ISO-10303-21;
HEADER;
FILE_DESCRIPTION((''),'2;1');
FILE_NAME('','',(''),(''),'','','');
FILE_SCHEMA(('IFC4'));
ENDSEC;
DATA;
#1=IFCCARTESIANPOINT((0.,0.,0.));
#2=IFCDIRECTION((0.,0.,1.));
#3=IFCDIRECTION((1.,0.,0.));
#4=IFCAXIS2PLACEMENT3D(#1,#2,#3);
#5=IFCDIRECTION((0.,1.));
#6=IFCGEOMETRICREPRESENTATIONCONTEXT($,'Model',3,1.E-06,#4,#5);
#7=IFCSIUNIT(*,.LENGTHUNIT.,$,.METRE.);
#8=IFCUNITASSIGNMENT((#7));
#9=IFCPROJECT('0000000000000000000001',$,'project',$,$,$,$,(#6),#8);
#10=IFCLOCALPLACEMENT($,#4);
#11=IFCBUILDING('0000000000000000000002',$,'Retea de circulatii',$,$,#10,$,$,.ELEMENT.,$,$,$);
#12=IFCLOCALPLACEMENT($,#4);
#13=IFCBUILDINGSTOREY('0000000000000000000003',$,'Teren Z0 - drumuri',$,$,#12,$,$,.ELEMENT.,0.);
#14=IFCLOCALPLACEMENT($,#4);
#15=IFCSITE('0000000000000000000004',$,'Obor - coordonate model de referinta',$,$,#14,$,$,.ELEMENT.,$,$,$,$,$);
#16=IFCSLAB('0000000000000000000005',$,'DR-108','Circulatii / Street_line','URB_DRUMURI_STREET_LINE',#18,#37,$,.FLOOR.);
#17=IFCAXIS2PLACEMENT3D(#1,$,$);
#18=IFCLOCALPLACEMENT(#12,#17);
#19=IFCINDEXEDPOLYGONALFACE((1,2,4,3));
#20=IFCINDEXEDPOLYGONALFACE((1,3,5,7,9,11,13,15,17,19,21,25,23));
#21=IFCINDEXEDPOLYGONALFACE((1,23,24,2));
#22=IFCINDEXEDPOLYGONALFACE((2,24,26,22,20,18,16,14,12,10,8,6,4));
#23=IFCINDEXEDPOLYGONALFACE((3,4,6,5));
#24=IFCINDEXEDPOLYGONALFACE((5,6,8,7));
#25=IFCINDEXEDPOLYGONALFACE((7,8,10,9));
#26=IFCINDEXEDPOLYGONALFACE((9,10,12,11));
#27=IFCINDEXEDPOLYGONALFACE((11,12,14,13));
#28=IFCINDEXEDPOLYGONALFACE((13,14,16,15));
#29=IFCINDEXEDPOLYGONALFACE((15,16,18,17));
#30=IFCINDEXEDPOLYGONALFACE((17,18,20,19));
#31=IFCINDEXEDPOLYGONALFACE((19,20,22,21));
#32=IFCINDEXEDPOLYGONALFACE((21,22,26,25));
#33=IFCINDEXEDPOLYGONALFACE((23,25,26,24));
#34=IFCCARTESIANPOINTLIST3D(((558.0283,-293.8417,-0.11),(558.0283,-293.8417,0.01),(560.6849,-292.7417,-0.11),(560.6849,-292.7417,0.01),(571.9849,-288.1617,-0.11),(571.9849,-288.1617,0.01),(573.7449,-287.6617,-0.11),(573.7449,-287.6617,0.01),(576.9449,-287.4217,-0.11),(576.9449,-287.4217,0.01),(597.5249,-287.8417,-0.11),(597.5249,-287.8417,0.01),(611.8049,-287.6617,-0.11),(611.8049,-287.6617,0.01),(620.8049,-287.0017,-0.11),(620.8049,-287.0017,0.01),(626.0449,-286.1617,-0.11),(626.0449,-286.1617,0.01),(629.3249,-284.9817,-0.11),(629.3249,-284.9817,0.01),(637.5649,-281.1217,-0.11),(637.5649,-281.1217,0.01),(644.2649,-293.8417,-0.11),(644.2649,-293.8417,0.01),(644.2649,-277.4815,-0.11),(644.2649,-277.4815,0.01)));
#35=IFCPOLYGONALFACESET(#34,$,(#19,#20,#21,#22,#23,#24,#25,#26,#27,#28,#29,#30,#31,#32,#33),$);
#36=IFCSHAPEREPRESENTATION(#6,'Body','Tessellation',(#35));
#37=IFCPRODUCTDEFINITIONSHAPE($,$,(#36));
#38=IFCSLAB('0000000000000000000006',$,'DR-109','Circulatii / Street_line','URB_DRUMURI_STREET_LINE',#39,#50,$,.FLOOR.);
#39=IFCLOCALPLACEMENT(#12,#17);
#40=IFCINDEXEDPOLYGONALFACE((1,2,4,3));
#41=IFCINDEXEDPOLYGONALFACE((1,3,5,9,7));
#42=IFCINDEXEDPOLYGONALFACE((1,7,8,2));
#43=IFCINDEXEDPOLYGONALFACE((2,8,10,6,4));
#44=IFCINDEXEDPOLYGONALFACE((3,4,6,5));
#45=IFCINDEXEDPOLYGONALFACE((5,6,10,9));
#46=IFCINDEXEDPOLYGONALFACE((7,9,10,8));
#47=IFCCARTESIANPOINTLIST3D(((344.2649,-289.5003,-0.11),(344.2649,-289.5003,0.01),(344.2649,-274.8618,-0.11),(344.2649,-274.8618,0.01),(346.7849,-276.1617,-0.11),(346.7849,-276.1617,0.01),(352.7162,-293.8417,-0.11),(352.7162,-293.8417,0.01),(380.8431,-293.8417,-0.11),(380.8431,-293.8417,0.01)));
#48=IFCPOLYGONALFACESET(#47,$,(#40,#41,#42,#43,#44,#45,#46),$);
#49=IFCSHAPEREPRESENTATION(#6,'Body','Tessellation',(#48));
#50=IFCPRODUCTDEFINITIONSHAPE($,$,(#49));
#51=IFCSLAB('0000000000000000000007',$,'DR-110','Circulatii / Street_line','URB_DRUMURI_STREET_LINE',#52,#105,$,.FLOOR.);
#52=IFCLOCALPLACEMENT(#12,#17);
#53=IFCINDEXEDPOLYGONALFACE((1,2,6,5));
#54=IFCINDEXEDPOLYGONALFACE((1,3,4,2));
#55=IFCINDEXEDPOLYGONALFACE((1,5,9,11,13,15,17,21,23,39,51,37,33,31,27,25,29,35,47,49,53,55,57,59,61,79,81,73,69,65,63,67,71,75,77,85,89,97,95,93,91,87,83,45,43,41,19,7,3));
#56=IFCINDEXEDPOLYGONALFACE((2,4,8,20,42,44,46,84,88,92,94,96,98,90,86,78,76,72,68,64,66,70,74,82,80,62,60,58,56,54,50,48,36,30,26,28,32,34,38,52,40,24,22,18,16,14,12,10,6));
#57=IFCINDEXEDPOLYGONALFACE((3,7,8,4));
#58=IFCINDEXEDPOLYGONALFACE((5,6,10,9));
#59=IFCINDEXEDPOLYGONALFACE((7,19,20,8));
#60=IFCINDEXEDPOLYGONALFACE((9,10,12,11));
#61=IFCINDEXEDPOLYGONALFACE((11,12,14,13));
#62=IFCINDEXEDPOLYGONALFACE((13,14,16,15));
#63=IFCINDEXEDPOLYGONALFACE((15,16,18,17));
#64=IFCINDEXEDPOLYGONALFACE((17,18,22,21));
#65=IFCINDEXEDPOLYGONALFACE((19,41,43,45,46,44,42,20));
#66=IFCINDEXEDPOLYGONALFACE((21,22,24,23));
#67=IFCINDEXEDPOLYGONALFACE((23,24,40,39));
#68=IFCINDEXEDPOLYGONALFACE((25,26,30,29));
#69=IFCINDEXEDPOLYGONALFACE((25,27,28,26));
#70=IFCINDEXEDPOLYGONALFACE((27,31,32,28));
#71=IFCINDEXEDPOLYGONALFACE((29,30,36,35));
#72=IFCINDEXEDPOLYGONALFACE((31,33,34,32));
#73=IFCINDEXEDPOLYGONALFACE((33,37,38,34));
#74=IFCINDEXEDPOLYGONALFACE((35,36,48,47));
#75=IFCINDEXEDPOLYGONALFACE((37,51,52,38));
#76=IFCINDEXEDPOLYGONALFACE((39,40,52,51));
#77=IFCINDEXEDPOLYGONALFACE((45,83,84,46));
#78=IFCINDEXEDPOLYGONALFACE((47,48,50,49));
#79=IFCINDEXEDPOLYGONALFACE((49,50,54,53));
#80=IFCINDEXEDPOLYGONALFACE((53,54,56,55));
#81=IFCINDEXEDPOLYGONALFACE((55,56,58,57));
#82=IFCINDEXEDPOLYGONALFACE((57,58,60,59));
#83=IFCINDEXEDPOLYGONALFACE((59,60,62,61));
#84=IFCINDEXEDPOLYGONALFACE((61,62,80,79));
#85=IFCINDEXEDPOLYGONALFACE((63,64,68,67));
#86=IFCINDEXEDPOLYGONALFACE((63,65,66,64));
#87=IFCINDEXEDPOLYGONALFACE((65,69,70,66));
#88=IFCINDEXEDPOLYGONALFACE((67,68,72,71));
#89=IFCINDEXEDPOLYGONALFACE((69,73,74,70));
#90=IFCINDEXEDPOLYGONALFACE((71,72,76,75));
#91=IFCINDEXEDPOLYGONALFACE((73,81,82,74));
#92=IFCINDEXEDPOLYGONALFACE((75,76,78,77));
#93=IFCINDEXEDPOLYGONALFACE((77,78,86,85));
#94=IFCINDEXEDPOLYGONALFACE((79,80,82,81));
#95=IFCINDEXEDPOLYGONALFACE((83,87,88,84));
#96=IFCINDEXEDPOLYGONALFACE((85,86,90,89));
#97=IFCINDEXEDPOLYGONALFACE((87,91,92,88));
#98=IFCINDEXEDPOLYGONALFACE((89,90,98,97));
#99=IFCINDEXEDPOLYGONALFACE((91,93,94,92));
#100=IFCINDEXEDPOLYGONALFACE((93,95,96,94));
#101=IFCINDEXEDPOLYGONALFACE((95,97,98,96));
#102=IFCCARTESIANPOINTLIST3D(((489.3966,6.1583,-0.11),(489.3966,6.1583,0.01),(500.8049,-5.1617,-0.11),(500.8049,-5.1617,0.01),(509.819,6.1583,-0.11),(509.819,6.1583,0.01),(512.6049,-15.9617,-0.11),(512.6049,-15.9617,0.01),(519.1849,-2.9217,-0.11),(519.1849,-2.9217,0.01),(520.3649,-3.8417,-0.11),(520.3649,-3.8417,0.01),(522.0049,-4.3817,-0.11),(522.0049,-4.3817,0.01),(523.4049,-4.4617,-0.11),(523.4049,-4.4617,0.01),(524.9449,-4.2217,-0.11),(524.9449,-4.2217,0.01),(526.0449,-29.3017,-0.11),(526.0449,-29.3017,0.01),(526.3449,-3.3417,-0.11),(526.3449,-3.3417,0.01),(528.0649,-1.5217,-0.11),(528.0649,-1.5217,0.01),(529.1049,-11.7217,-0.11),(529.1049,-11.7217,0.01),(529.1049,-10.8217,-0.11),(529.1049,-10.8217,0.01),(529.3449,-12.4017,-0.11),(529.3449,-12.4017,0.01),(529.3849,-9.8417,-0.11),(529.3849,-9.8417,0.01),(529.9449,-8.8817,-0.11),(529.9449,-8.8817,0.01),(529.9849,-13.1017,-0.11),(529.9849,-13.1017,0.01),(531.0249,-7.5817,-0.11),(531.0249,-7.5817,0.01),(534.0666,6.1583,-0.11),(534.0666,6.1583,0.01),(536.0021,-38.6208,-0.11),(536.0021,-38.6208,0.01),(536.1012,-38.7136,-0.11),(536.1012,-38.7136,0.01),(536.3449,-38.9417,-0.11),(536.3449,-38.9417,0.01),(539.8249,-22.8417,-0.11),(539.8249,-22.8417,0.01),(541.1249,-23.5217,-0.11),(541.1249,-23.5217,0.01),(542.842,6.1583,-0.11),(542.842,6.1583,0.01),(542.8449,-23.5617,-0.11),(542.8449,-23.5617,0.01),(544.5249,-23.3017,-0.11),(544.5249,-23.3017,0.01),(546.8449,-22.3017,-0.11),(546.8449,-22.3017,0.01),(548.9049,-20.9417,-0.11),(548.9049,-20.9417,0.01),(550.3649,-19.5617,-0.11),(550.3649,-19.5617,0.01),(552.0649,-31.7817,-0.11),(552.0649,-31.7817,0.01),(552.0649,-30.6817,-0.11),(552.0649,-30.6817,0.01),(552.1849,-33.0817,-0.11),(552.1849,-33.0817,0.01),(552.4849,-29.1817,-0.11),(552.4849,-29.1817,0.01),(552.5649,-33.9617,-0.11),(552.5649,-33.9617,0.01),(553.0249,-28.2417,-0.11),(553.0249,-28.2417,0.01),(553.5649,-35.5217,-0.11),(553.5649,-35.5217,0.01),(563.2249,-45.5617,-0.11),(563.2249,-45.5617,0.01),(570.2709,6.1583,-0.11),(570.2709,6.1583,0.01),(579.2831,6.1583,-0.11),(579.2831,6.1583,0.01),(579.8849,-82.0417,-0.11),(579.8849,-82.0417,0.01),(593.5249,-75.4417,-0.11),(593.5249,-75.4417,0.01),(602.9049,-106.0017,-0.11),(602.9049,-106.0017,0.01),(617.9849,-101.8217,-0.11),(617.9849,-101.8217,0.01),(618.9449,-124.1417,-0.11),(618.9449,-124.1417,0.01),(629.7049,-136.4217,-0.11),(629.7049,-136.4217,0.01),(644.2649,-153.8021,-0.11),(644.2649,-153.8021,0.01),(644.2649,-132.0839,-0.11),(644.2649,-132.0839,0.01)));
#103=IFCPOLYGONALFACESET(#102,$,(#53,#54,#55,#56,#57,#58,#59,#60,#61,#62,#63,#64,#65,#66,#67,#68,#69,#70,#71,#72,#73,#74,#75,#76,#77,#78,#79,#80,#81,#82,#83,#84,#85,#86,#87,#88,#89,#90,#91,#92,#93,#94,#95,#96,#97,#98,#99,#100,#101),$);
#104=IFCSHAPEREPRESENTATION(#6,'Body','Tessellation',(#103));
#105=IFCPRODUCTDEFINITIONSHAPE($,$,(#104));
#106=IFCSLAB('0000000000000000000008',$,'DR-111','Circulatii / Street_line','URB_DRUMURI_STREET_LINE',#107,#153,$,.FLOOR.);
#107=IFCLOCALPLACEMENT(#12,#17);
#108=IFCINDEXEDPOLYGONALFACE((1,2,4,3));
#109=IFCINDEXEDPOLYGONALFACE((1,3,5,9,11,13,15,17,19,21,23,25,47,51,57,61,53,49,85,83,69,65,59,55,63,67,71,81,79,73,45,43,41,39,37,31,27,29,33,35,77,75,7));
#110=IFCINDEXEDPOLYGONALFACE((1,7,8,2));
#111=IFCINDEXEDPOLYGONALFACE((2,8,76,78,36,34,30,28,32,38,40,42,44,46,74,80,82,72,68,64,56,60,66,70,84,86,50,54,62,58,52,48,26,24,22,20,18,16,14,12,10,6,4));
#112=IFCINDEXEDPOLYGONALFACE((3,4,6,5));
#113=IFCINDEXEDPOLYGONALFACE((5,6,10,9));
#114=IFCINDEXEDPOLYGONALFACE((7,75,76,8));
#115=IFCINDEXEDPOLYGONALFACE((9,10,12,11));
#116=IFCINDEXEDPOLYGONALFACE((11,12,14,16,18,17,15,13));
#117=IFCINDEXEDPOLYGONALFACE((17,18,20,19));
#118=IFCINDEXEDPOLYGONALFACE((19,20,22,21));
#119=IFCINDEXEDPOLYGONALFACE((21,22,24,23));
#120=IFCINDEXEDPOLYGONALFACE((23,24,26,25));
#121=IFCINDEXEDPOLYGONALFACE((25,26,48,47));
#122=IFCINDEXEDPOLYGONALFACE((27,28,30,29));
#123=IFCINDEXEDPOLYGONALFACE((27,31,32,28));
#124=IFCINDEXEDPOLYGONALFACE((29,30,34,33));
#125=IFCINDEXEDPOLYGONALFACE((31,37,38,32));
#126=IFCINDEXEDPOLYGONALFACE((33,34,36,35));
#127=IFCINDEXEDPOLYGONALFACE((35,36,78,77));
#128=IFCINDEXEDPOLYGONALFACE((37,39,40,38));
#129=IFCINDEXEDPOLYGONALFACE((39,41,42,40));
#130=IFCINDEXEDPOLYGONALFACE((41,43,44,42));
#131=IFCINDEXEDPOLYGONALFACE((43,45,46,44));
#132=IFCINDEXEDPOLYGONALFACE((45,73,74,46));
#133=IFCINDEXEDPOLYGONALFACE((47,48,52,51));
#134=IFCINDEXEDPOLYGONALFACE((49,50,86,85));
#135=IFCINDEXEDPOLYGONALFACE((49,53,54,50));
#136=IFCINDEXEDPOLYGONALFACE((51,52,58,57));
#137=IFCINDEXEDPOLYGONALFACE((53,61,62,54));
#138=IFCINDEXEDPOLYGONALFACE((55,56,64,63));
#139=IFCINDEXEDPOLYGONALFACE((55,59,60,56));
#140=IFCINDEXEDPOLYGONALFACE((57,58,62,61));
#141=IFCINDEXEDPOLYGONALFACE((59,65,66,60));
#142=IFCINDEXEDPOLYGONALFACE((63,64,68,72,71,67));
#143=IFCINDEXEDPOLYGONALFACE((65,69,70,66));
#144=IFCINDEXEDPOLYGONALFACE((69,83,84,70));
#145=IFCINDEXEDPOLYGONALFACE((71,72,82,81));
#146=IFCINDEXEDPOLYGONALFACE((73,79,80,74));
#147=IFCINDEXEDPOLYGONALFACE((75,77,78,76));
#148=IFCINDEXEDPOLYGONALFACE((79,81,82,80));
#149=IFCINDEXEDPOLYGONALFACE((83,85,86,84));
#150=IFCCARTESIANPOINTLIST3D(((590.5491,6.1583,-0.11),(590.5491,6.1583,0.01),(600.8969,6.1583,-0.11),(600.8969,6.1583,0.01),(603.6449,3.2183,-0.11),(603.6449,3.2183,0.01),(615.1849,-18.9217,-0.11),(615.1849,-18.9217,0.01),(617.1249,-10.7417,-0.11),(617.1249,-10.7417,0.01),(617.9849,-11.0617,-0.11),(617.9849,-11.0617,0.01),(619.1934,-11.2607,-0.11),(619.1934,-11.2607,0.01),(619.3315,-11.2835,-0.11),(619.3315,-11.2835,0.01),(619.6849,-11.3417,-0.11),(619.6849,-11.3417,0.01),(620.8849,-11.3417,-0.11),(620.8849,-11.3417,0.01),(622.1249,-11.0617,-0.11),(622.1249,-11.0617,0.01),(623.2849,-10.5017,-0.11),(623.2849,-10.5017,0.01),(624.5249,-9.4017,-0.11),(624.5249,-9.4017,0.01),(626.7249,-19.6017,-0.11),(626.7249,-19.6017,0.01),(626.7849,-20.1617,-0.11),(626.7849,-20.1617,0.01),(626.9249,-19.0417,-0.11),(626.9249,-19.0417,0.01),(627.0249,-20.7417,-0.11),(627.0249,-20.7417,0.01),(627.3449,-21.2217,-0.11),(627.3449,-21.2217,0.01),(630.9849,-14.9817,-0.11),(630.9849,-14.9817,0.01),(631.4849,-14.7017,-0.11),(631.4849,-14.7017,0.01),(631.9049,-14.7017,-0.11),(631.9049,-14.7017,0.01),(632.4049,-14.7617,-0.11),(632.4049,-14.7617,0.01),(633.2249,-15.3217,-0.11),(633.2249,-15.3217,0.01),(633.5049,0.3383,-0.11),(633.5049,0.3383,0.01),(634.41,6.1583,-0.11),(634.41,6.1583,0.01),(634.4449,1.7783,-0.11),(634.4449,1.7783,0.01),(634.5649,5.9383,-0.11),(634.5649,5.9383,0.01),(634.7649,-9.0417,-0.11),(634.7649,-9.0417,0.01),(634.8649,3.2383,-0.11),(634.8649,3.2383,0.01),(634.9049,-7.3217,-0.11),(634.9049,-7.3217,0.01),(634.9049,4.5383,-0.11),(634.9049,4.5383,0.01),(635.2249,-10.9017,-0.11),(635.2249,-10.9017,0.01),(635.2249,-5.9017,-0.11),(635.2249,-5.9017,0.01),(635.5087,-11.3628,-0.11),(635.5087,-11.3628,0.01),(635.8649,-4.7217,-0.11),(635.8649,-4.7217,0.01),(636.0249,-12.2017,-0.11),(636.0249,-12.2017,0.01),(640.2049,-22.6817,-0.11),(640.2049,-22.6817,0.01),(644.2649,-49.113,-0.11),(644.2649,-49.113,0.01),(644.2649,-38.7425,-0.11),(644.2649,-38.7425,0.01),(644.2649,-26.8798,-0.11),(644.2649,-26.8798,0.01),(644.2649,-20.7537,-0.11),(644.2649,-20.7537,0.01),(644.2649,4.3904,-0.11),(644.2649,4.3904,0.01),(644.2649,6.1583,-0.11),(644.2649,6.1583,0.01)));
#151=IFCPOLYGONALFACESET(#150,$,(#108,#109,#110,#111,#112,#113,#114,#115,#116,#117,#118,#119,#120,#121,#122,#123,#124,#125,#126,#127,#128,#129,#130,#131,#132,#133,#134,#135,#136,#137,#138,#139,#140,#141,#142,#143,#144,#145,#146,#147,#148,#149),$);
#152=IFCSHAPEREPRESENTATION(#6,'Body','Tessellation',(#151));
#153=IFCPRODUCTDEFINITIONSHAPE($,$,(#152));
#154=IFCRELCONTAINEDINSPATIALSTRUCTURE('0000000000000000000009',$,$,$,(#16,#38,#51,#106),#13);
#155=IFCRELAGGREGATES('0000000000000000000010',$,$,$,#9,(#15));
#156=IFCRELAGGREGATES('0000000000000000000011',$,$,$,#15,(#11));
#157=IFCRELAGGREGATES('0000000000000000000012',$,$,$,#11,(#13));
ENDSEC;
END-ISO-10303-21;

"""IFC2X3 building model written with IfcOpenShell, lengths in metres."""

from ifc_helpers import new_model, si_unit, direction, frame, origin_with_axes, place, context, project, spatial, polyline, outline, extrude, element, save


model = new_model("IFC2X3")

# Units and contexts
model_context = context("Model", 3, precision=1e-06, world=origin_with_axes(), true_north=direction((0.0, 1.0)))
ifc_project = project(units=[si_unit("LENGTHUNIT", "METRE")], contexts=[model_context])

# Site, building, storey
site_placement = place(None, origin_with_axes())
site = spatial("IfcSite", under=ifc_project, at=site_placement, Name="Obor - coordonate model de referinta", CompositionType="ELEMENT")
building_placement = place(None, origin_with_axes())
building = spatial("IfcBuilding", under=site, at=building_placement, Name="Retea de circulatii", CompositionType="ELEMENT")
storey_placement = place(None, origin_with_axes())
storey = spatial("IfcBuildingStorey", under=building, at=storey_placement, Name="Teren Z0 - drumuri", CompositionType="ELEMENT", Elevation=0.0)

# Slabs
slab_1_placement = place(None, origin_with_axes())
element("IfcSlab", 1, at=slab_1_placement, inside=storey, Name="DR-108", Description="Circulatii / Street_line", ObjectType="URB_DRUMURI_STREET_LINE", PredefinedType="FLOOR", context=model_context, shape_type="SweptSolid", body=[
    extrude(outline(polyline([(597.5249, -287.8417), (576.9449, -287.4217), (573.7449, -287.6617), (571.9849, -288.1617), (560.6849, -292.7417), (558.0283, -293.8417), (644.2649, -293.8417), (644.2649, -277.4815), (637.5649, -281.1217), (629.3249, -284.9817), (626.0449, -286.1617), (620.8049, -287.0017), (611.8049, -287.6617), (597.5249, -287.8417)])), frame((0.0, 0.0, -0.11), z_axis=(0.0, 0.0, 1.0), x_axis=(1.0, 0.0, 0.0)), (0.0, 0.0, 1.0), 0.12),
])
slab_2_placement = place(None, origin_with_axes())
element("IfcSlab", 2, at=slab_2_placement, inside=storey, Name="DR-109", Description="Circulatii / Street_line", ObjectType="URB_DRUMURI_STREET_LINE", PredefinedType="FLOOR", context=model_context, shape_type="SweptSolid", body=[
    extrude(outline(polyline([(346.7849, -276.1617), (344.2649, -274.8618), (344.2649, -289.5003), (352.7162, -293.8417), (380.8431, -293.8417), (346.7849, -276.1617)])), frame((0.0, 0.0, -0.11), z_axis=(0.0, 0.0, 1.0), x_axis=(1.0, 0.0, 0.0)), (0.0, 0.0, 1.0), 0.12),
])
slab_3_placement = place(None, origin_with_axes())
element("IfcSlab", 3, at=slab_3_placement, inside=storey, Name="DR-110", Description="Circulatii / Street_line", ObjectType="URB_DRUMURI_STREET_LINE", PredefinedType="FLOOR", context=model_context, shape_type="SweptSolid", body=[
    extrude(outline(polyline([(602.9049, -106.0017), (618.9449, -124.1417), (629.7049, -136.4217), (644.2649, -153.8021), (644.2649, -132.0839), (617.9849, -101.8217), (593.5249, -75.4417), (563.2249, -45.5617), (553.5649, -35.5217), (552.5649, -33.9617), (552.1849, -33.0817), (552.0649, -31.7817), (552.0649, -30.6817), (552.4849, -29.1817), (553.0249, -28.2417), (579.2831, 6.1583), (570.2709, 6.1583), (550.3649, -19.5617), (548.9049, -20.9417), (546.8449, -22.3017), (544.5249, -23.3017), (542.8449, -23.5617), (541.1249, -23.5217), (539.8249, -22.8417), (529.9849, -13.1017), (529.3449, -12.4017), (529.1049, -11.7217), (529.1049, -10.8217), (529.3849, -9.8417), (529.9449, -8.8817), (531.0249, -7.5817), (542.842, 6.1583), (534.0666, 6.1583), (528.0649, -1.5217), (526.3449, -3.3417), (524.9449, -4.2217), (523.4049, -4.4617), (522.0049, -4.3817), (520.3649, -3.8417), (519.1849, -2.9217), (509.819, 6.1583), (489.3966, 6.1583), (500.8049, -5.1617), (512.6049, -15.9617), (526.0449, -29.3017), (536.0021, -38.6208), (536.1012, -38.7136), (536.3449, -38.9417), (579.8849, -82.0417), (602.9049, -106.0017)])), frame((0.0, 0.0, -0.11), z_axis=(0.0, 0.0, 1.0), x_axis=(1.0, 0.0, 0.0)), (0.0, 0.0, 1.0), 0.12),
])
slab_4_placement = place(None, origin_with_axes())
element("IfcSlab", 4, at=slab_4_placement, inside=storey, Name="DR-111", Description="Circulatii / Street_line", ObjectType="URB_DRUMURI_STREET_LINE", PredefinedType="FLOOR", context=model_context, shape_type="SweptSolid", body=[
    extrude(outline(polyline([(600.8969, 6.1583), (590.5491, 6.1583), (615.1849, -18.9217), (644.2649, -49.113), (644.2649, -38.7425), (627.3449, -21.2217), (627.0249, -20.7417), (626.7849, -20.1617), (626.7249, -19.6017), (626.9249, -19.0417), (630.9849, -14.9817), (631.4849, -14.7017), (631.9049, -14.7017), (632.4049, -14.7617), (633.2249, -15.3217), (640.2049, -22.6817), (644.2649, -26.8798), (644.2649, -20.7537), (636.0249, -12.2017), (635.5087, -11.3628), (635.2249, -10.9017), (634.7649, -9.0417), (634.9049, -7.3217), (635.2249, -5.9017), (635.8649, -4.7217), (644.2649, 4.3904), (644.2649, 6.1583), (634.41, 6.1583), (634.5649, 5.9383), (634.9049, 4.5383), (634.8649, 3.2383), (634.4449, 1.7783), (633.5049, 0.3383), (624.5249, -9.4017), (623.2849, -10.5017), (622.1249, -11.0617), (620.8849, -11.3417), (619.6849, -11.3417), (619.3315, -11.2835), (619.1934, -11.2607), (617.9849, -11.0617), (617.1249, -10.7417), (603.6449, 3.2183), (600.8969, 6.1583)])), frame((0.0, 0.0, -0.11), z_axis=(0.0, 0.0, 1.0), x_axis=(1.0, 0.0, 0.0)), (0.0, 0.0, 1.0), 0.12),
])

save(model, "model.ifc")
